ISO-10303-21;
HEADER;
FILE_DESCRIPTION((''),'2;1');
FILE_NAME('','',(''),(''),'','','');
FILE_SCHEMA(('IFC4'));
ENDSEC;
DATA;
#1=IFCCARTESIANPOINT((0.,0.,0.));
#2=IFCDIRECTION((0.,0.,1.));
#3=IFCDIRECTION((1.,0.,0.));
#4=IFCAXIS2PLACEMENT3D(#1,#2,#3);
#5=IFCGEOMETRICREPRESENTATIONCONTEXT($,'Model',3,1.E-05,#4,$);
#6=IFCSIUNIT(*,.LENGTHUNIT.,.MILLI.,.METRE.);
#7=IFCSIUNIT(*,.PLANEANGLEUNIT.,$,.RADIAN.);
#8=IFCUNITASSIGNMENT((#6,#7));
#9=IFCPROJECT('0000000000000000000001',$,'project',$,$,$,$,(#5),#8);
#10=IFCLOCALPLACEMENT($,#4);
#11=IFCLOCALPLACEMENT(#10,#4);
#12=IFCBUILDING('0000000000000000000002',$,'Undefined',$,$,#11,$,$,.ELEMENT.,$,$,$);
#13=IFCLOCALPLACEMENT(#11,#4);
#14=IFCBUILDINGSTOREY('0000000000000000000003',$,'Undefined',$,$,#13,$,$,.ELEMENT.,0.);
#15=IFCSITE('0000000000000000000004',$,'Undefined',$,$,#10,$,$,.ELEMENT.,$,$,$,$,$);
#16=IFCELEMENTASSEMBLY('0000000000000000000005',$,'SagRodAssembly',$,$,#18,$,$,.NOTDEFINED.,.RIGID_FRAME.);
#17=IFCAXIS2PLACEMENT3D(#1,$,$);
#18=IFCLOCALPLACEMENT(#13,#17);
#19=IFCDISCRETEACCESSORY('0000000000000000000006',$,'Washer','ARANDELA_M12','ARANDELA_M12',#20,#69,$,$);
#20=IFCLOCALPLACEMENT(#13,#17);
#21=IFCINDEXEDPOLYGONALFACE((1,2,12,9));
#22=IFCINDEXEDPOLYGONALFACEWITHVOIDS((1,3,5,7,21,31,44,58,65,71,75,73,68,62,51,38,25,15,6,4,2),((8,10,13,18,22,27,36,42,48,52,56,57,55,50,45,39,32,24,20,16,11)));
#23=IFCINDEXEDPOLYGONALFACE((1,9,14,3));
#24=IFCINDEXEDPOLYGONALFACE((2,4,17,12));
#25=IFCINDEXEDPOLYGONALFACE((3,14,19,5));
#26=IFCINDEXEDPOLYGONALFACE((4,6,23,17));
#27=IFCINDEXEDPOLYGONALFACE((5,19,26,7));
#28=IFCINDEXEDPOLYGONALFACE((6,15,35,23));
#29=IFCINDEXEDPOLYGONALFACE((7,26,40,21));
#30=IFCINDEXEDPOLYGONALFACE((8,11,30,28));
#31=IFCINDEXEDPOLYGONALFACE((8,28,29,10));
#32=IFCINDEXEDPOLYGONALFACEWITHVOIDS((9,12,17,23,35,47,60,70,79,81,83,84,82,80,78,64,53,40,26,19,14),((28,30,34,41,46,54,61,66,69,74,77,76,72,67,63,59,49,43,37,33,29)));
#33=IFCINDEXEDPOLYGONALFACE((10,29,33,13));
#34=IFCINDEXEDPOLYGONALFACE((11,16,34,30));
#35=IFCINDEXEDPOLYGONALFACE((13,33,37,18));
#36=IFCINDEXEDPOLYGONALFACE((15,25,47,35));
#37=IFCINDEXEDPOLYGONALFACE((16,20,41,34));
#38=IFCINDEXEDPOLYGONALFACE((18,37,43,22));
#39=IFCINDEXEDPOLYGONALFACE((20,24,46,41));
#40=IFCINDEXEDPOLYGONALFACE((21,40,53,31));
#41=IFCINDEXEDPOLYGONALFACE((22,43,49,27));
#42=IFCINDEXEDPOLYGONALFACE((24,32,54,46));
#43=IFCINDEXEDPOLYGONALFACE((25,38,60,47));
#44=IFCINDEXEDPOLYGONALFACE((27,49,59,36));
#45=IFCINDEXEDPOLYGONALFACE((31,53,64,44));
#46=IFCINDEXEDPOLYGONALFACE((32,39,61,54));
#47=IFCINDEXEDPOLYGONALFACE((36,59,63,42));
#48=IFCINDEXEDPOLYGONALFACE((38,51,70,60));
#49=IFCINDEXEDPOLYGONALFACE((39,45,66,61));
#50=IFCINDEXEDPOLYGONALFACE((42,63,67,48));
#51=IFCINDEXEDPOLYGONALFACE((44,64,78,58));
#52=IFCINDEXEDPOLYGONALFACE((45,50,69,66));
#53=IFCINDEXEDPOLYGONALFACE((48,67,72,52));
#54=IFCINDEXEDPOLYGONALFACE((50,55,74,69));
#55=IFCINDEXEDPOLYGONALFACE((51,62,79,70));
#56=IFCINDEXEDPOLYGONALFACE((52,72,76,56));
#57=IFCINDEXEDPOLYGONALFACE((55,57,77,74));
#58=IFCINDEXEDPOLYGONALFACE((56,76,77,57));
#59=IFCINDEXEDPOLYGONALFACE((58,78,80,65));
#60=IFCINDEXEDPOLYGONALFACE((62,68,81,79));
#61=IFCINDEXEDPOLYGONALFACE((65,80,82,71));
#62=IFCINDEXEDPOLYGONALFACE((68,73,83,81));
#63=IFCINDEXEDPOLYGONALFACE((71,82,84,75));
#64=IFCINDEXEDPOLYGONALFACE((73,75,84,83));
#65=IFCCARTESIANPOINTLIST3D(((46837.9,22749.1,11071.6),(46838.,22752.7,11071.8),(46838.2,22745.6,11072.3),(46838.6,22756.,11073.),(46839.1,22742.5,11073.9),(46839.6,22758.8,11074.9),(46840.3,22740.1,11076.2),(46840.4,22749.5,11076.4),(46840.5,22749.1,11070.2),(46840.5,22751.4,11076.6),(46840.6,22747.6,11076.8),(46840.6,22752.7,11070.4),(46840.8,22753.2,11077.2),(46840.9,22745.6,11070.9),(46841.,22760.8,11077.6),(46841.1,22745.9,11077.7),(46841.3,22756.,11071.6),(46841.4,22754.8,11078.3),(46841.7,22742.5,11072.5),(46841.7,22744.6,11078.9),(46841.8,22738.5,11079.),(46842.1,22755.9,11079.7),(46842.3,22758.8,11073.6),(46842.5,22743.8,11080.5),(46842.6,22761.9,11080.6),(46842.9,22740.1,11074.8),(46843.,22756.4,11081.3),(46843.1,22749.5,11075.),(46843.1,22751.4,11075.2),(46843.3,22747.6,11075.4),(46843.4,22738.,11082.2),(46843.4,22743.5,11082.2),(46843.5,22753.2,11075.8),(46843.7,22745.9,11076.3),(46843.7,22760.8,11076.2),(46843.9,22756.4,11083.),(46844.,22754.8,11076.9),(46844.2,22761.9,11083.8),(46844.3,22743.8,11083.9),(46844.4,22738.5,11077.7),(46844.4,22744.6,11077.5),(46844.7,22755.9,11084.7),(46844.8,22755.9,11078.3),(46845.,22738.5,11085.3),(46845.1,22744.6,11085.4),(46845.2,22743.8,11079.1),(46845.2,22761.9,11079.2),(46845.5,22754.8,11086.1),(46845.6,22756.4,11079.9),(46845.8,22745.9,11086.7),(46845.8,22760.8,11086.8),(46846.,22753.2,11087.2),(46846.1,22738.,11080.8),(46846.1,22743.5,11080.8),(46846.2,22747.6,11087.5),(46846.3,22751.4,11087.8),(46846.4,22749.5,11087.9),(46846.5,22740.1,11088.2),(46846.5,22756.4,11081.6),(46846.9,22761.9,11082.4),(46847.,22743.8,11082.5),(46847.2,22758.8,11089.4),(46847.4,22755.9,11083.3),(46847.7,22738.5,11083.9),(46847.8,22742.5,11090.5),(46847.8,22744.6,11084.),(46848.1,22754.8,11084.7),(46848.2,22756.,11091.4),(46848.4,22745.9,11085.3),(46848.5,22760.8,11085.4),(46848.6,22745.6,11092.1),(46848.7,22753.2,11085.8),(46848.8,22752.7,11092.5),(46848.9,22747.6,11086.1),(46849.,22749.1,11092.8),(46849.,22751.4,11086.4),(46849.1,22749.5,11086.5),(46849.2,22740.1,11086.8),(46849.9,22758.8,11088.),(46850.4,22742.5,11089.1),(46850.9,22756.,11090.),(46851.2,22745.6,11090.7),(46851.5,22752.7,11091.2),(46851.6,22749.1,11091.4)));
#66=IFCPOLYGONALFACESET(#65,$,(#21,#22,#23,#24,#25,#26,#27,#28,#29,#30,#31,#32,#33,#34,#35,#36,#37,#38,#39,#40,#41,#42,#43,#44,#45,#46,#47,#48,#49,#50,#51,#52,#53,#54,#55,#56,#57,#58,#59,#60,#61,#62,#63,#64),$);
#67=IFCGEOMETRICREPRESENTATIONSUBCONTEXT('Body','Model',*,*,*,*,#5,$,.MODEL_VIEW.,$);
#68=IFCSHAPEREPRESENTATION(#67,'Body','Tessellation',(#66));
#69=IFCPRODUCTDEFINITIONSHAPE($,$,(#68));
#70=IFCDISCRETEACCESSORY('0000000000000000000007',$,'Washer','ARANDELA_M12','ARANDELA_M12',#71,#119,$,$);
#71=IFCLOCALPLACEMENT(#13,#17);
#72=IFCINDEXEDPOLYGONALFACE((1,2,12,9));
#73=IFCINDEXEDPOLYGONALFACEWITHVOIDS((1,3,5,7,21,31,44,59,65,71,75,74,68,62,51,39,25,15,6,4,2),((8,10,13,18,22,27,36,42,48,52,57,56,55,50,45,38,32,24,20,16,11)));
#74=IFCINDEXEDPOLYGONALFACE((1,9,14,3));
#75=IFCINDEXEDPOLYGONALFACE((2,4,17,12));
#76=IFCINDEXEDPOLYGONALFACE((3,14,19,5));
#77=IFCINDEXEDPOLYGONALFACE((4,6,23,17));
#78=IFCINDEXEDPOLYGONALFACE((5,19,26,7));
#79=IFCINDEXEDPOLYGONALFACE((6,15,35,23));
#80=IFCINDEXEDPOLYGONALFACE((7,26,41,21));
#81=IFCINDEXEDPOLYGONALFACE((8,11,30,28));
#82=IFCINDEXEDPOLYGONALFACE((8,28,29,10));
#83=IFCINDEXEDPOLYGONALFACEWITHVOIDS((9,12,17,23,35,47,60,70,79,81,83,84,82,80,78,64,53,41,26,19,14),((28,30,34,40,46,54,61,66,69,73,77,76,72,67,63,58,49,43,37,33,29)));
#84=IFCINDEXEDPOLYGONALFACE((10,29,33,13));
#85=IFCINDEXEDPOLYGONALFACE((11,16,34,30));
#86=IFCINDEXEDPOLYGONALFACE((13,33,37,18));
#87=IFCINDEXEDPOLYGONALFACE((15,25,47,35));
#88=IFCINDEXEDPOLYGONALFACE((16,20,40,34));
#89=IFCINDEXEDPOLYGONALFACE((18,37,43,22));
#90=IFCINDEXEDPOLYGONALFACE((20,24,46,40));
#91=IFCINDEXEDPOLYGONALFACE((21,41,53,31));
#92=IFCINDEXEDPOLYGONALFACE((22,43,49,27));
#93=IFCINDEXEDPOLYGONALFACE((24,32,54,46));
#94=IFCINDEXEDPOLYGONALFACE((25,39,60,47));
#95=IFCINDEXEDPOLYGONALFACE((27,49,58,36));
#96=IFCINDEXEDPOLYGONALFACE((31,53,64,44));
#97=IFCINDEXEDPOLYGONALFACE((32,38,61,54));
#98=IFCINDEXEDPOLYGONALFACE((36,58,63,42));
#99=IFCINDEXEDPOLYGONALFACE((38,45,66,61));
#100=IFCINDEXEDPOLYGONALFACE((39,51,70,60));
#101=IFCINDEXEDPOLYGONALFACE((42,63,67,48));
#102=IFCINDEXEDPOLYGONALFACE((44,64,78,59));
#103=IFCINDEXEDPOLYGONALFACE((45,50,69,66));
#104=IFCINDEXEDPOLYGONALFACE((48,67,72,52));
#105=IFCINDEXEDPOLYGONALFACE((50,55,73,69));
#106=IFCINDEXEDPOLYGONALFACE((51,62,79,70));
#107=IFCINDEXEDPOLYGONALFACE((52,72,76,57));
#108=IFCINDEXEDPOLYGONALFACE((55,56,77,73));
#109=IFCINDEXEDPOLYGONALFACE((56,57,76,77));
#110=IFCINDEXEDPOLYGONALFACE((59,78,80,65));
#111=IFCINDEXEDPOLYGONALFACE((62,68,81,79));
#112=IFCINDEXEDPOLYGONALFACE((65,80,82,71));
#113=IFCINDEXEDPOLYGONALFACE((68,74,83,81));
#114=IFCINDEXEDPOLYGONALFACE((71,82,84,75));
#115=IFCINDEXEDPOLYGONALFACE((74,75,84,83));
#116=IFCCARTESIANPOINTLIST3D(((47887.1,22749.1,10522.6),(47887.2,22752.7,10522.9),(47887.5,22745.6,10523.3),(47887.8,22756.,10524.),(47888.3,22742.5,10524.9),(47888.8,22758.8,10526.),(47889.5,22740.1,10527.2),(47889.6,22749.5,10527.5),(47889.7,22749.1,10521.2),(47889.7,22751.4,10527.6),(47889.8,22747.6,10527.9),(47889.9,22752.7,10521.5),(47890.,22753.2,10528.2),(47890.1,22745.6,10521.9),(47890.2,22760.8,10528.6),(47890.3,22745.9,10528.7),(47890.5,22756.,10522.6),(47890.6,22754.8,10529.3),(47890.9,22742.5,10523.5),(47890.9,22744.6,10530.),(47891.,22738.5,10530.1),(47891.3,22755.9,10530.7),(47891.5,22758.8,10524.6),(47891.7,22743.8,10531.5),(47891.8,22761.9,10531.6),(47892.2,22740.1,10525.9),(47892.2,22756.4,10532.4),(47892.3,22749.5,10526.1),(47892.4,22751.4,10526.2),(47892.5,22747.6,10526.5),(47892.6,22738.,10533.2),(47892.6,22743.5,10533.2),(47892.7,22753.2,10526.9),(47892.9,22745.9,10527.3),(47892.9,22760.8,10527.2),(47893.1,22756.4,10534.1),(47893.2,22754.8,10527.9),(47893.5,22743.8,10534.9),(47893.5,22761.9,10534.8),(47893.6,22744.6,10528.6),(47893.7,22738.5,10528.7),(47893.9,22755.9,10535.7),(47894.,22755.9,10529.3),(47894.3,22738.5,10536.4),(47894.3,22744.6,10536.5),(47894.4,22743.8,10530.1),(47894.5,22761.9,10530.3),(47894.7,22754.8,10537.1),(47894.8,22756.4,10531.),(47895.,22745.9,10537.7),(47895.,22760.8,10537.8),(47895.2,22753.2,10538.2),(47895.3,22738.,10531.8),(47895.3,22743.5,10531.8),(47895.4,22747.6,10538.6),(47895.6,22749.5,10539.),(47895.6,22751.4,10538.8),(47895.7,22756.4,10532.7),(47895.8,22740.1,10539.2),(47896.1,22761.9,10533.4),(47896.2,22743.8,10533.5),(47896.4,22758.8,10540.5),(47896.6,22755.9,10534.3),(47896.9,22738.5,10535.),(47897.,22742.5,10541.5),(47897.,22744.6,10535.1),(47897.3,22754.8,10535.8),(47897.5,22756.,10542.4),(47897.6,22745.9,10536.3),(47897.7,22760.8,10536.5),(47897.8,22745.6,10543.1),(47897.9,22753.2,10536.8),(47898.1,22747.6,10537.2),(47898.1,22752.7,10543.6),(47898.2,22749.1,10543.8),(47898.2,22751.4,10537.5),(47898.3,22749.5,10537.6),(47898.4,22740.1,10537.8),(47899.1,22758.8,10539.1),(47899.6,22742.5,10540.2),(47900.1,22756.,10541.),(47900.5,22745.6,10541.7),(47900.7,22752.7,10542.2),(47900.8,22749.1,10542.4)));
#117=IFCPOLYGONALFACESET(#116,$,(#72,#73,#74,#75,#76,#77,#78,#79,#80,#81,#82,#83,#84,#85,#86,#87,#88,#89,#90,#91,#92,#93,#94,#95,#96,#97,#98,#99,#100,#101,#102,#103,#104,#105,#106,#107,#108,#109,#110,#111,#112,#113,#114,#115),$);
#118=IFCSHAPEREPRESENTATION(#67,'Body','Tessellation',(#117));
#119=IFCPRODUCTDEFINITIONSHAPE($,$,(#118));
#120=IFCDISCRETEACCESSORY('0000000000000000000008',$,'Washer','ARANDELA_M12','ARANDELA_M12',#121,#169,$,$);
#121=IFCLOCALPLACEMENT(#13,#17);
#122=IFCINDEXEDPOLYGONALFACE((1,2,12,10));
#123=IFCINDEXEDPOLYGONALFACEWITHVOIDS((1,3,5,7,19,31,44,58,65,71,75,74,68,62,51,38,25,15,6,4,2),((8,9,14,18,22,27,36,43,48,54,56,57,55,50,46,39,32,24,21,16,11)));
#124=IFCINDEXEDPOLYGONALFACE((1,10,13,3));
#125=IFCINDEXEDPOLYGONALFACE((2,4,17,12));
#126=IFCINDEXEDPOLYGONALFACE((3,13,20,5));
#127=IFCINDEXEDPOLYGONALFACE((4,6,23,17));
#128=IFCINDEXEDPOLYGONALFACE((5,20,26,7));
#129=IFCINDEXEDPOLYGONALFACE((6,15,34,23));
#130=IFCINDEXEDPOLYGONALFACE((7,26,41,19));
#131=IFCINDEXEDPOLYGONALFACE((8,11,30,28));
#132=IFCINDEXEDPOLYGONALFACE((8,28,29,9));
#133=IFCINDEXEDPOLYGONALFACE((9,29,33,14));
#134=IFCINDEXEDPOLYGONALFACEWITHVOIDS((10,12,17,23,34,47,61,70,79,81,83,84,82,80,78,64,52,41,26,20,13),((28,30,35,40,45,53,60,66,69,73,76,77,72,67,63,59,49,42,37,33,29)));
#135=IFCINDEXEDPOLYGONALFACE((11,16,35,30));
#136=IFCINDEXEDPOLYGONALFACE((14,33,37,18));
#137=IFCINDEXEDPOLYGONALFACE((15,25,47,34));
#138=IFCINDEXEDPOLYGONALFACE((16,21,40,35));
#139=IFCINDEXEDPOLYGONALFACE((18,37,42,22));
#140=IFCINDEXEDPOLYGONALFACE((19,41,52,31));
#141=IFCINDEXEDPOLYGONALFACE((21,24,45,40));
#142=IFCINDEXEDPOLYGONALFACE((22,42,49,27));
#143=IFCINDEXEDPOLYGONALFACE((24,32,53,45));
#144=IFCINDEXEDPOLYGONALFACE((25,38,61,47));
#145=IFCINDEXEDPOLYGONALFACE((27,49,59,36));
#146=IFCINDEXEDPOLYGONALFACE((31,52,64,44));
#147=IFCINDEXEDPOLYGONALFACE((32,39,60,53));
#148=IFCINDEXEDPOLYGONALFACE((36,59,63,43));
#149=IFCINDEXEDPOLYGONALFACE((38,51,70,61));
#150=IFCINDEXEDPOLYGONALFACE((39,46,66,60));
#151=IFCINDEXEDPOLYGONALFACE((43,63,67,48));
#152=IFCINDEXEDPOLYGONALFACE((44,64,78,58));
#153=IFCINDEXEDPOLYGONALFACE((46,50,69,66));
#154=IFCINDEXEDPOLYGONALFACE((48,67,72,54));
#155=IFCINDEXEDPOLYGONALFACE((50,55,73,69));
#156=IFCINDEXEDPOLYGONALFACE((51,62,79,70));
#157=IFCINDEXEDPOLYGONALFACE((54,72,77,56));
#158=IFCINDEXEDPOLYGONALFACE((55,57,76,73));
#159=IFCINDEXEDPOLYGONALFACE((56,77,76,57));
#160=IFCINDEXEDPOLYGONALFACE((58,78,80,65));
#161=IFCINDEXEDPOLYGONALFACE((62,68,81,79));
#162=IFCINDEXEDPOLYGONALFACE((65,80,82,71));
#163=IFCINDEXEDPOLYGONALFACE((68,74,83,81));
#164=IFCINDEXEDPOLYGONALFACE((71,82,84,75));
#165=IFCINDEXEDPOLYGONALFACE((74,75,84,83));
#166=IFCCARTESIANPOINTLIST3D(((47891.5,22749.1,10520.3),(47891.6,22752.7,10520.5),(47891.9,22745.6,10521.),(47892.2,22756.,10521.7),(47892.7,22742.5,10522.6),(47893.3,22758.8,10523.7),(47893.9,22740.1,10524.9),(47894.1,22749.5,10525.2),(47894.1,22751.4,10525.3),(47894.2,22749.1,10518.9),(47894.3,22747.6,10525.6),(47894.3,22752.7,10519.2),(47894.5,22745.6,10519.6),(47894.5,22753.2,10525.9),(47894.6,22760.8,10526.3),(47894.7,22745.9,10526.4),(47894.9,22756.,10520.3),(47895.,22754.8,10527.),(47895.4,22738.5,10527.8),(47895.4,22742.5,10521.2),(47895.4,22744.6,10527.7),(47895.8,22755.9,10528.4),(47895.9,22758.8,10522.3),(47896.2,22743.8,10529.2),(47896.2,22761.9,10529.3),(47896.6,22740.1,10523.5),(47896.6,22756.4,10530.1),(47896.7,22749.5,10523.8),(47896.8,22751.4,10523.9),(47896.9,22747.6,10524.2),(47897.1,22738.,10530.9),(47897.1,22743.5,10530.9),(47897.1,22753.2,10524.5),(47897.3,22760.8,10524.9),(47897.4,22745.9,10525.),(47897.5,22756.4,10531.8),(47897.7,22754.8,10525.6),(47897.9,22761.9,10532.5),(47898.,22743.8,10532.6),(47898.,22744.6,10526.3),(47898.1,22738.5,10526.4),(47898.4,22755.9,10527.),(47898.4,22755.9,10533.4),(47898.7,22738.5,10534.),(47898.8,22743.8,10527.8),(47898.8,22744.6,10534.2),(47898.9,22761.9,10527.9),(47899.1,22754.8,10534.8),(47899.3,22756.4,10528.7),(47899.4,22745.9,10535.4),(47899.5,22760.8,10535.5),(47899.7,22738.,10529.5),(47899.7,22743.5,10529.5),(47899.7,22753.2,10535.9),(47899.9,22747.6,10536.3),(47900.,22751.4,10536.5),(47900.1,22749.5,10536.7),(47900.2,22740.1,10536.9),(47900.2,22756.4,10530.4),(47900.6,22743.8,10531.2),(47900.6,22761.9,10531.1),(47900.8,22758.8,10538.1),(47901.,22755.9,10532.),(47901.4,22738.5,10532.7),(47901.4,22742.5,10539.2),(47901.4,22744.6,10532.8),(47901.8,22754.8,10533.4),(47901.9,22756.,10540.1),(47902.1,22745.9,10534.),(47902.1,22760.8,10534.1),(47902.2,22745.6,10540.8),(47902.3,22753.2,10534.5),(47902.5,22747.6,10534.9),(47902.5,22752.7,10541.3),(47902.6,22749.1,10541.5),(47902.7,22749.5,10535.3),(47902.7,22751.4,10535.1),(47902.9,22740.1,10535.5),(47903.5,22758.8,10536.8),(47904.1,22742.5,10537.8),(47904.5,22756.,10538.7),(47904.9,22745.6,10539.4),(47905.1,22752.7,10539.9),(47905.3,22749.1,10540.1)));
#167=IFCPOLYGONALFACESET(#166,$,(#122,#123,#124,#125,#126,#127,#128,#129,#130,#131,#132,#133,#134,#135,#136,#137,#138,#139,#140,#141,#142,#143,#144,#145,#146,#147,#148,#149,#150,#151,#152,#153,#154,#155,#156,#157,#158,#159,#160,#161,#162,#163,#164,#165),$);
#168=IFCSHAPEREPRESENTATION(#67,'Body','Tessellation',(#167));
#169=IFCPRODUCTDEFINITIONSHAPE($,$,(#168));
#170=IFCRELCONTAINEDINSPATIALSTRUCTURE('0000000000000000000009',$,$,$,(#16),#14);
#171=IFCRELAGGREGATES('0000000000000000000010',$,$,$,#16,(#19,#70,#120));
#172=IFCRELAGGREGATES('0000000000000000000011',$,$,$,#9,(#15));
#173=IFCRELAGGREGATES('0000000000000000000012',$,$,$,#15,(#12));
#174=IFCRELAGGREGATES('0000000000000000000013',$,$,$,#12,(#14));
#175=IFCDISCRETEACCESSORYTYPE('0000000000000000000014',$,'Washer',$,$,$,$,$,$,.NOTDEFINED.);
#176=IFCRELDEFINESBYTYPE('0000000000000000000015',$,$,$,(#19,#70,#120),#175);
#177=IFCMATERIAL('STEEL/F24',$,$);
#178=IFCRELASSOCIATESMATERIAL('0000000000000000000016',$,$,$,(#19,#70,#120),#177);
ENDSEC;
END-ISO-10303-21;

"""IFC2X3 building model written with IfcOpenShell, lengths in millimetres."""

from ifc_helpers import new_model, si_unit, frame, origin_with_axes, origin_2d_with_axis, place, context, subcontext, project, spatial, hollow_circle, extrude, material, type_object, element, aggregate, save


model = new_model("IFC2X3")

# Units and contexts
model_context = context("Model", 3, precision=1e-05, world=origin_with_axes())
body_context = subcontext(model_context, "Body", "Model", "MODEL_VIEW")
ifc_project = project(units=[si_unit("LENGTHUNIT", "METRE", prefix="MILLI"), si_unit("PLANEANGLEUNIT", "RADIAN")], contexts=[model_context])

# Site, building, storey
site_placement = place(None, origin_with_axes())
site = spatial("IfcSite", under=ifc_project, at=site_placement, Name="Undefined", CompositionType="ELEMENT")
building_placement = place(site_placement, origin_with_axes())
building = spatial("IfcBuilding", under=site, at=building_placement, Name="Undefined", CompositionType="ELEMENT")
storey_placement = place(building_placement, origin_with_axes())
storey = spatial("IfcBuildingStorey", under=building, at=storey_placement, Name="Undefined", CompositionType="ELEMENT", Elevation=0.0)

# Element assembly
ifc_material_1 = material(Name="STEEL/F24")
assembly_1_placement = place(storey_placement, origin_with_axes())
assembly_1 = element("IfcElementAssembly", 1, at=assembly_1_placement, inside=storey, Name="SagRodAssembly", AssemblyPlace="NOTDEFINED", PredefinedType="RIGID_FRAME")

# Discrete accessories
discrete_accessory_type_1 = type_object("IfcDiscreteAccessoryType", Name="Washer")
discrete_accessory_1_placement = place(assembly_1_placement, frame((46846.1, 22750.0, 11080.8), z_axis=(-0.463578, 0.0, -0.886056), x_axis=(-0.886056, 0.0, 0.463578)))
discrete_accessory_1 = element("IfcDiscreteAccessory", 2, at=discrete_accessory_1_placement, type_object=discrete_accessory_type_1, material=ifc_material_1, Name="Washer", Description="ARANDELA_M12", ObjectType="ARANDELA_M12", context=body_context, shape_type="SweptSolid", body=[
    extrude(hollow_circle(Radius=12.0, WallThickness=5.5, at=origin_2d_with_axis()), frame((3.0, 0.0, 0.0), z_axis=(-1.0, 0.0, 0.0), x_axis=(0.0, -1.0, 0.0)), (0.0, 0.0, 1.0), 3.0),
])
discrete_accessory_2_placement = place(assembly_1_placement, frame((47895.3, 22750.0, 10531.8), z_axis=(-0.463578, 0.0, -0.886056), x_axis=(-0.886056, 0.0, 0.463578)))
discrete_accessory_2 = element("IfcDiscreteAccessory", 3, at=discrete_accessory_2_placement, type_object=discrete_accessory_type_1, material=ifc_material_1, Name="Washer", Description="ARANDELA_M12", ObjectType="ARANDELA_M12", context=body_context, shape_type="SweptSolid", body=[
    extrude(hollow_circle(Radius=12.0, WallThickness=5.5, at=origin_2d_with_axis()), frame((3.0, 0.0, 0.0), z_axis=(-1.0, 0.0, 0.0), x_axis=(0.0, -1.0, 0.0)), (0.0, 0.0, 1.0), 3.0),
])
discrete_accessory_3_placement = place(assembly_1_placement, frame((47899.7, 22750.0, 10529.5), z_axis=(-0.463578, 0.0, -0.886056), x_axis=(-0.886056, 0.0, 0.463578)))
discrete_accessory_3 = element("IfcDiscreteAccessory", 4, at=discrete_accessory_3_placement, type_object=discrete_accessory_type_1, material=ifc_material_1, Name="Washer", Description="ARANDELA_M12", ObjectType="ARANDELA_M12", context=body_context, shape_type="SweptSolid", body=[
    extrude(hollow_circle(Radius=12.0, WallThickness=5.5, at=origin_2d_with_axis()), frame((3.0, 0.0, 0.0), z_axis=(-1.0, 0.0, 0.0), x_axis=(0.0, -1.0, 0.0)), (0.0, 0.0, 1.0), 3.0),
])
aggregate(assembly_1, [discrete_accessory_1, discrete_accessory_2, discrete_accessory_3])

save(model, "model.ifc")
